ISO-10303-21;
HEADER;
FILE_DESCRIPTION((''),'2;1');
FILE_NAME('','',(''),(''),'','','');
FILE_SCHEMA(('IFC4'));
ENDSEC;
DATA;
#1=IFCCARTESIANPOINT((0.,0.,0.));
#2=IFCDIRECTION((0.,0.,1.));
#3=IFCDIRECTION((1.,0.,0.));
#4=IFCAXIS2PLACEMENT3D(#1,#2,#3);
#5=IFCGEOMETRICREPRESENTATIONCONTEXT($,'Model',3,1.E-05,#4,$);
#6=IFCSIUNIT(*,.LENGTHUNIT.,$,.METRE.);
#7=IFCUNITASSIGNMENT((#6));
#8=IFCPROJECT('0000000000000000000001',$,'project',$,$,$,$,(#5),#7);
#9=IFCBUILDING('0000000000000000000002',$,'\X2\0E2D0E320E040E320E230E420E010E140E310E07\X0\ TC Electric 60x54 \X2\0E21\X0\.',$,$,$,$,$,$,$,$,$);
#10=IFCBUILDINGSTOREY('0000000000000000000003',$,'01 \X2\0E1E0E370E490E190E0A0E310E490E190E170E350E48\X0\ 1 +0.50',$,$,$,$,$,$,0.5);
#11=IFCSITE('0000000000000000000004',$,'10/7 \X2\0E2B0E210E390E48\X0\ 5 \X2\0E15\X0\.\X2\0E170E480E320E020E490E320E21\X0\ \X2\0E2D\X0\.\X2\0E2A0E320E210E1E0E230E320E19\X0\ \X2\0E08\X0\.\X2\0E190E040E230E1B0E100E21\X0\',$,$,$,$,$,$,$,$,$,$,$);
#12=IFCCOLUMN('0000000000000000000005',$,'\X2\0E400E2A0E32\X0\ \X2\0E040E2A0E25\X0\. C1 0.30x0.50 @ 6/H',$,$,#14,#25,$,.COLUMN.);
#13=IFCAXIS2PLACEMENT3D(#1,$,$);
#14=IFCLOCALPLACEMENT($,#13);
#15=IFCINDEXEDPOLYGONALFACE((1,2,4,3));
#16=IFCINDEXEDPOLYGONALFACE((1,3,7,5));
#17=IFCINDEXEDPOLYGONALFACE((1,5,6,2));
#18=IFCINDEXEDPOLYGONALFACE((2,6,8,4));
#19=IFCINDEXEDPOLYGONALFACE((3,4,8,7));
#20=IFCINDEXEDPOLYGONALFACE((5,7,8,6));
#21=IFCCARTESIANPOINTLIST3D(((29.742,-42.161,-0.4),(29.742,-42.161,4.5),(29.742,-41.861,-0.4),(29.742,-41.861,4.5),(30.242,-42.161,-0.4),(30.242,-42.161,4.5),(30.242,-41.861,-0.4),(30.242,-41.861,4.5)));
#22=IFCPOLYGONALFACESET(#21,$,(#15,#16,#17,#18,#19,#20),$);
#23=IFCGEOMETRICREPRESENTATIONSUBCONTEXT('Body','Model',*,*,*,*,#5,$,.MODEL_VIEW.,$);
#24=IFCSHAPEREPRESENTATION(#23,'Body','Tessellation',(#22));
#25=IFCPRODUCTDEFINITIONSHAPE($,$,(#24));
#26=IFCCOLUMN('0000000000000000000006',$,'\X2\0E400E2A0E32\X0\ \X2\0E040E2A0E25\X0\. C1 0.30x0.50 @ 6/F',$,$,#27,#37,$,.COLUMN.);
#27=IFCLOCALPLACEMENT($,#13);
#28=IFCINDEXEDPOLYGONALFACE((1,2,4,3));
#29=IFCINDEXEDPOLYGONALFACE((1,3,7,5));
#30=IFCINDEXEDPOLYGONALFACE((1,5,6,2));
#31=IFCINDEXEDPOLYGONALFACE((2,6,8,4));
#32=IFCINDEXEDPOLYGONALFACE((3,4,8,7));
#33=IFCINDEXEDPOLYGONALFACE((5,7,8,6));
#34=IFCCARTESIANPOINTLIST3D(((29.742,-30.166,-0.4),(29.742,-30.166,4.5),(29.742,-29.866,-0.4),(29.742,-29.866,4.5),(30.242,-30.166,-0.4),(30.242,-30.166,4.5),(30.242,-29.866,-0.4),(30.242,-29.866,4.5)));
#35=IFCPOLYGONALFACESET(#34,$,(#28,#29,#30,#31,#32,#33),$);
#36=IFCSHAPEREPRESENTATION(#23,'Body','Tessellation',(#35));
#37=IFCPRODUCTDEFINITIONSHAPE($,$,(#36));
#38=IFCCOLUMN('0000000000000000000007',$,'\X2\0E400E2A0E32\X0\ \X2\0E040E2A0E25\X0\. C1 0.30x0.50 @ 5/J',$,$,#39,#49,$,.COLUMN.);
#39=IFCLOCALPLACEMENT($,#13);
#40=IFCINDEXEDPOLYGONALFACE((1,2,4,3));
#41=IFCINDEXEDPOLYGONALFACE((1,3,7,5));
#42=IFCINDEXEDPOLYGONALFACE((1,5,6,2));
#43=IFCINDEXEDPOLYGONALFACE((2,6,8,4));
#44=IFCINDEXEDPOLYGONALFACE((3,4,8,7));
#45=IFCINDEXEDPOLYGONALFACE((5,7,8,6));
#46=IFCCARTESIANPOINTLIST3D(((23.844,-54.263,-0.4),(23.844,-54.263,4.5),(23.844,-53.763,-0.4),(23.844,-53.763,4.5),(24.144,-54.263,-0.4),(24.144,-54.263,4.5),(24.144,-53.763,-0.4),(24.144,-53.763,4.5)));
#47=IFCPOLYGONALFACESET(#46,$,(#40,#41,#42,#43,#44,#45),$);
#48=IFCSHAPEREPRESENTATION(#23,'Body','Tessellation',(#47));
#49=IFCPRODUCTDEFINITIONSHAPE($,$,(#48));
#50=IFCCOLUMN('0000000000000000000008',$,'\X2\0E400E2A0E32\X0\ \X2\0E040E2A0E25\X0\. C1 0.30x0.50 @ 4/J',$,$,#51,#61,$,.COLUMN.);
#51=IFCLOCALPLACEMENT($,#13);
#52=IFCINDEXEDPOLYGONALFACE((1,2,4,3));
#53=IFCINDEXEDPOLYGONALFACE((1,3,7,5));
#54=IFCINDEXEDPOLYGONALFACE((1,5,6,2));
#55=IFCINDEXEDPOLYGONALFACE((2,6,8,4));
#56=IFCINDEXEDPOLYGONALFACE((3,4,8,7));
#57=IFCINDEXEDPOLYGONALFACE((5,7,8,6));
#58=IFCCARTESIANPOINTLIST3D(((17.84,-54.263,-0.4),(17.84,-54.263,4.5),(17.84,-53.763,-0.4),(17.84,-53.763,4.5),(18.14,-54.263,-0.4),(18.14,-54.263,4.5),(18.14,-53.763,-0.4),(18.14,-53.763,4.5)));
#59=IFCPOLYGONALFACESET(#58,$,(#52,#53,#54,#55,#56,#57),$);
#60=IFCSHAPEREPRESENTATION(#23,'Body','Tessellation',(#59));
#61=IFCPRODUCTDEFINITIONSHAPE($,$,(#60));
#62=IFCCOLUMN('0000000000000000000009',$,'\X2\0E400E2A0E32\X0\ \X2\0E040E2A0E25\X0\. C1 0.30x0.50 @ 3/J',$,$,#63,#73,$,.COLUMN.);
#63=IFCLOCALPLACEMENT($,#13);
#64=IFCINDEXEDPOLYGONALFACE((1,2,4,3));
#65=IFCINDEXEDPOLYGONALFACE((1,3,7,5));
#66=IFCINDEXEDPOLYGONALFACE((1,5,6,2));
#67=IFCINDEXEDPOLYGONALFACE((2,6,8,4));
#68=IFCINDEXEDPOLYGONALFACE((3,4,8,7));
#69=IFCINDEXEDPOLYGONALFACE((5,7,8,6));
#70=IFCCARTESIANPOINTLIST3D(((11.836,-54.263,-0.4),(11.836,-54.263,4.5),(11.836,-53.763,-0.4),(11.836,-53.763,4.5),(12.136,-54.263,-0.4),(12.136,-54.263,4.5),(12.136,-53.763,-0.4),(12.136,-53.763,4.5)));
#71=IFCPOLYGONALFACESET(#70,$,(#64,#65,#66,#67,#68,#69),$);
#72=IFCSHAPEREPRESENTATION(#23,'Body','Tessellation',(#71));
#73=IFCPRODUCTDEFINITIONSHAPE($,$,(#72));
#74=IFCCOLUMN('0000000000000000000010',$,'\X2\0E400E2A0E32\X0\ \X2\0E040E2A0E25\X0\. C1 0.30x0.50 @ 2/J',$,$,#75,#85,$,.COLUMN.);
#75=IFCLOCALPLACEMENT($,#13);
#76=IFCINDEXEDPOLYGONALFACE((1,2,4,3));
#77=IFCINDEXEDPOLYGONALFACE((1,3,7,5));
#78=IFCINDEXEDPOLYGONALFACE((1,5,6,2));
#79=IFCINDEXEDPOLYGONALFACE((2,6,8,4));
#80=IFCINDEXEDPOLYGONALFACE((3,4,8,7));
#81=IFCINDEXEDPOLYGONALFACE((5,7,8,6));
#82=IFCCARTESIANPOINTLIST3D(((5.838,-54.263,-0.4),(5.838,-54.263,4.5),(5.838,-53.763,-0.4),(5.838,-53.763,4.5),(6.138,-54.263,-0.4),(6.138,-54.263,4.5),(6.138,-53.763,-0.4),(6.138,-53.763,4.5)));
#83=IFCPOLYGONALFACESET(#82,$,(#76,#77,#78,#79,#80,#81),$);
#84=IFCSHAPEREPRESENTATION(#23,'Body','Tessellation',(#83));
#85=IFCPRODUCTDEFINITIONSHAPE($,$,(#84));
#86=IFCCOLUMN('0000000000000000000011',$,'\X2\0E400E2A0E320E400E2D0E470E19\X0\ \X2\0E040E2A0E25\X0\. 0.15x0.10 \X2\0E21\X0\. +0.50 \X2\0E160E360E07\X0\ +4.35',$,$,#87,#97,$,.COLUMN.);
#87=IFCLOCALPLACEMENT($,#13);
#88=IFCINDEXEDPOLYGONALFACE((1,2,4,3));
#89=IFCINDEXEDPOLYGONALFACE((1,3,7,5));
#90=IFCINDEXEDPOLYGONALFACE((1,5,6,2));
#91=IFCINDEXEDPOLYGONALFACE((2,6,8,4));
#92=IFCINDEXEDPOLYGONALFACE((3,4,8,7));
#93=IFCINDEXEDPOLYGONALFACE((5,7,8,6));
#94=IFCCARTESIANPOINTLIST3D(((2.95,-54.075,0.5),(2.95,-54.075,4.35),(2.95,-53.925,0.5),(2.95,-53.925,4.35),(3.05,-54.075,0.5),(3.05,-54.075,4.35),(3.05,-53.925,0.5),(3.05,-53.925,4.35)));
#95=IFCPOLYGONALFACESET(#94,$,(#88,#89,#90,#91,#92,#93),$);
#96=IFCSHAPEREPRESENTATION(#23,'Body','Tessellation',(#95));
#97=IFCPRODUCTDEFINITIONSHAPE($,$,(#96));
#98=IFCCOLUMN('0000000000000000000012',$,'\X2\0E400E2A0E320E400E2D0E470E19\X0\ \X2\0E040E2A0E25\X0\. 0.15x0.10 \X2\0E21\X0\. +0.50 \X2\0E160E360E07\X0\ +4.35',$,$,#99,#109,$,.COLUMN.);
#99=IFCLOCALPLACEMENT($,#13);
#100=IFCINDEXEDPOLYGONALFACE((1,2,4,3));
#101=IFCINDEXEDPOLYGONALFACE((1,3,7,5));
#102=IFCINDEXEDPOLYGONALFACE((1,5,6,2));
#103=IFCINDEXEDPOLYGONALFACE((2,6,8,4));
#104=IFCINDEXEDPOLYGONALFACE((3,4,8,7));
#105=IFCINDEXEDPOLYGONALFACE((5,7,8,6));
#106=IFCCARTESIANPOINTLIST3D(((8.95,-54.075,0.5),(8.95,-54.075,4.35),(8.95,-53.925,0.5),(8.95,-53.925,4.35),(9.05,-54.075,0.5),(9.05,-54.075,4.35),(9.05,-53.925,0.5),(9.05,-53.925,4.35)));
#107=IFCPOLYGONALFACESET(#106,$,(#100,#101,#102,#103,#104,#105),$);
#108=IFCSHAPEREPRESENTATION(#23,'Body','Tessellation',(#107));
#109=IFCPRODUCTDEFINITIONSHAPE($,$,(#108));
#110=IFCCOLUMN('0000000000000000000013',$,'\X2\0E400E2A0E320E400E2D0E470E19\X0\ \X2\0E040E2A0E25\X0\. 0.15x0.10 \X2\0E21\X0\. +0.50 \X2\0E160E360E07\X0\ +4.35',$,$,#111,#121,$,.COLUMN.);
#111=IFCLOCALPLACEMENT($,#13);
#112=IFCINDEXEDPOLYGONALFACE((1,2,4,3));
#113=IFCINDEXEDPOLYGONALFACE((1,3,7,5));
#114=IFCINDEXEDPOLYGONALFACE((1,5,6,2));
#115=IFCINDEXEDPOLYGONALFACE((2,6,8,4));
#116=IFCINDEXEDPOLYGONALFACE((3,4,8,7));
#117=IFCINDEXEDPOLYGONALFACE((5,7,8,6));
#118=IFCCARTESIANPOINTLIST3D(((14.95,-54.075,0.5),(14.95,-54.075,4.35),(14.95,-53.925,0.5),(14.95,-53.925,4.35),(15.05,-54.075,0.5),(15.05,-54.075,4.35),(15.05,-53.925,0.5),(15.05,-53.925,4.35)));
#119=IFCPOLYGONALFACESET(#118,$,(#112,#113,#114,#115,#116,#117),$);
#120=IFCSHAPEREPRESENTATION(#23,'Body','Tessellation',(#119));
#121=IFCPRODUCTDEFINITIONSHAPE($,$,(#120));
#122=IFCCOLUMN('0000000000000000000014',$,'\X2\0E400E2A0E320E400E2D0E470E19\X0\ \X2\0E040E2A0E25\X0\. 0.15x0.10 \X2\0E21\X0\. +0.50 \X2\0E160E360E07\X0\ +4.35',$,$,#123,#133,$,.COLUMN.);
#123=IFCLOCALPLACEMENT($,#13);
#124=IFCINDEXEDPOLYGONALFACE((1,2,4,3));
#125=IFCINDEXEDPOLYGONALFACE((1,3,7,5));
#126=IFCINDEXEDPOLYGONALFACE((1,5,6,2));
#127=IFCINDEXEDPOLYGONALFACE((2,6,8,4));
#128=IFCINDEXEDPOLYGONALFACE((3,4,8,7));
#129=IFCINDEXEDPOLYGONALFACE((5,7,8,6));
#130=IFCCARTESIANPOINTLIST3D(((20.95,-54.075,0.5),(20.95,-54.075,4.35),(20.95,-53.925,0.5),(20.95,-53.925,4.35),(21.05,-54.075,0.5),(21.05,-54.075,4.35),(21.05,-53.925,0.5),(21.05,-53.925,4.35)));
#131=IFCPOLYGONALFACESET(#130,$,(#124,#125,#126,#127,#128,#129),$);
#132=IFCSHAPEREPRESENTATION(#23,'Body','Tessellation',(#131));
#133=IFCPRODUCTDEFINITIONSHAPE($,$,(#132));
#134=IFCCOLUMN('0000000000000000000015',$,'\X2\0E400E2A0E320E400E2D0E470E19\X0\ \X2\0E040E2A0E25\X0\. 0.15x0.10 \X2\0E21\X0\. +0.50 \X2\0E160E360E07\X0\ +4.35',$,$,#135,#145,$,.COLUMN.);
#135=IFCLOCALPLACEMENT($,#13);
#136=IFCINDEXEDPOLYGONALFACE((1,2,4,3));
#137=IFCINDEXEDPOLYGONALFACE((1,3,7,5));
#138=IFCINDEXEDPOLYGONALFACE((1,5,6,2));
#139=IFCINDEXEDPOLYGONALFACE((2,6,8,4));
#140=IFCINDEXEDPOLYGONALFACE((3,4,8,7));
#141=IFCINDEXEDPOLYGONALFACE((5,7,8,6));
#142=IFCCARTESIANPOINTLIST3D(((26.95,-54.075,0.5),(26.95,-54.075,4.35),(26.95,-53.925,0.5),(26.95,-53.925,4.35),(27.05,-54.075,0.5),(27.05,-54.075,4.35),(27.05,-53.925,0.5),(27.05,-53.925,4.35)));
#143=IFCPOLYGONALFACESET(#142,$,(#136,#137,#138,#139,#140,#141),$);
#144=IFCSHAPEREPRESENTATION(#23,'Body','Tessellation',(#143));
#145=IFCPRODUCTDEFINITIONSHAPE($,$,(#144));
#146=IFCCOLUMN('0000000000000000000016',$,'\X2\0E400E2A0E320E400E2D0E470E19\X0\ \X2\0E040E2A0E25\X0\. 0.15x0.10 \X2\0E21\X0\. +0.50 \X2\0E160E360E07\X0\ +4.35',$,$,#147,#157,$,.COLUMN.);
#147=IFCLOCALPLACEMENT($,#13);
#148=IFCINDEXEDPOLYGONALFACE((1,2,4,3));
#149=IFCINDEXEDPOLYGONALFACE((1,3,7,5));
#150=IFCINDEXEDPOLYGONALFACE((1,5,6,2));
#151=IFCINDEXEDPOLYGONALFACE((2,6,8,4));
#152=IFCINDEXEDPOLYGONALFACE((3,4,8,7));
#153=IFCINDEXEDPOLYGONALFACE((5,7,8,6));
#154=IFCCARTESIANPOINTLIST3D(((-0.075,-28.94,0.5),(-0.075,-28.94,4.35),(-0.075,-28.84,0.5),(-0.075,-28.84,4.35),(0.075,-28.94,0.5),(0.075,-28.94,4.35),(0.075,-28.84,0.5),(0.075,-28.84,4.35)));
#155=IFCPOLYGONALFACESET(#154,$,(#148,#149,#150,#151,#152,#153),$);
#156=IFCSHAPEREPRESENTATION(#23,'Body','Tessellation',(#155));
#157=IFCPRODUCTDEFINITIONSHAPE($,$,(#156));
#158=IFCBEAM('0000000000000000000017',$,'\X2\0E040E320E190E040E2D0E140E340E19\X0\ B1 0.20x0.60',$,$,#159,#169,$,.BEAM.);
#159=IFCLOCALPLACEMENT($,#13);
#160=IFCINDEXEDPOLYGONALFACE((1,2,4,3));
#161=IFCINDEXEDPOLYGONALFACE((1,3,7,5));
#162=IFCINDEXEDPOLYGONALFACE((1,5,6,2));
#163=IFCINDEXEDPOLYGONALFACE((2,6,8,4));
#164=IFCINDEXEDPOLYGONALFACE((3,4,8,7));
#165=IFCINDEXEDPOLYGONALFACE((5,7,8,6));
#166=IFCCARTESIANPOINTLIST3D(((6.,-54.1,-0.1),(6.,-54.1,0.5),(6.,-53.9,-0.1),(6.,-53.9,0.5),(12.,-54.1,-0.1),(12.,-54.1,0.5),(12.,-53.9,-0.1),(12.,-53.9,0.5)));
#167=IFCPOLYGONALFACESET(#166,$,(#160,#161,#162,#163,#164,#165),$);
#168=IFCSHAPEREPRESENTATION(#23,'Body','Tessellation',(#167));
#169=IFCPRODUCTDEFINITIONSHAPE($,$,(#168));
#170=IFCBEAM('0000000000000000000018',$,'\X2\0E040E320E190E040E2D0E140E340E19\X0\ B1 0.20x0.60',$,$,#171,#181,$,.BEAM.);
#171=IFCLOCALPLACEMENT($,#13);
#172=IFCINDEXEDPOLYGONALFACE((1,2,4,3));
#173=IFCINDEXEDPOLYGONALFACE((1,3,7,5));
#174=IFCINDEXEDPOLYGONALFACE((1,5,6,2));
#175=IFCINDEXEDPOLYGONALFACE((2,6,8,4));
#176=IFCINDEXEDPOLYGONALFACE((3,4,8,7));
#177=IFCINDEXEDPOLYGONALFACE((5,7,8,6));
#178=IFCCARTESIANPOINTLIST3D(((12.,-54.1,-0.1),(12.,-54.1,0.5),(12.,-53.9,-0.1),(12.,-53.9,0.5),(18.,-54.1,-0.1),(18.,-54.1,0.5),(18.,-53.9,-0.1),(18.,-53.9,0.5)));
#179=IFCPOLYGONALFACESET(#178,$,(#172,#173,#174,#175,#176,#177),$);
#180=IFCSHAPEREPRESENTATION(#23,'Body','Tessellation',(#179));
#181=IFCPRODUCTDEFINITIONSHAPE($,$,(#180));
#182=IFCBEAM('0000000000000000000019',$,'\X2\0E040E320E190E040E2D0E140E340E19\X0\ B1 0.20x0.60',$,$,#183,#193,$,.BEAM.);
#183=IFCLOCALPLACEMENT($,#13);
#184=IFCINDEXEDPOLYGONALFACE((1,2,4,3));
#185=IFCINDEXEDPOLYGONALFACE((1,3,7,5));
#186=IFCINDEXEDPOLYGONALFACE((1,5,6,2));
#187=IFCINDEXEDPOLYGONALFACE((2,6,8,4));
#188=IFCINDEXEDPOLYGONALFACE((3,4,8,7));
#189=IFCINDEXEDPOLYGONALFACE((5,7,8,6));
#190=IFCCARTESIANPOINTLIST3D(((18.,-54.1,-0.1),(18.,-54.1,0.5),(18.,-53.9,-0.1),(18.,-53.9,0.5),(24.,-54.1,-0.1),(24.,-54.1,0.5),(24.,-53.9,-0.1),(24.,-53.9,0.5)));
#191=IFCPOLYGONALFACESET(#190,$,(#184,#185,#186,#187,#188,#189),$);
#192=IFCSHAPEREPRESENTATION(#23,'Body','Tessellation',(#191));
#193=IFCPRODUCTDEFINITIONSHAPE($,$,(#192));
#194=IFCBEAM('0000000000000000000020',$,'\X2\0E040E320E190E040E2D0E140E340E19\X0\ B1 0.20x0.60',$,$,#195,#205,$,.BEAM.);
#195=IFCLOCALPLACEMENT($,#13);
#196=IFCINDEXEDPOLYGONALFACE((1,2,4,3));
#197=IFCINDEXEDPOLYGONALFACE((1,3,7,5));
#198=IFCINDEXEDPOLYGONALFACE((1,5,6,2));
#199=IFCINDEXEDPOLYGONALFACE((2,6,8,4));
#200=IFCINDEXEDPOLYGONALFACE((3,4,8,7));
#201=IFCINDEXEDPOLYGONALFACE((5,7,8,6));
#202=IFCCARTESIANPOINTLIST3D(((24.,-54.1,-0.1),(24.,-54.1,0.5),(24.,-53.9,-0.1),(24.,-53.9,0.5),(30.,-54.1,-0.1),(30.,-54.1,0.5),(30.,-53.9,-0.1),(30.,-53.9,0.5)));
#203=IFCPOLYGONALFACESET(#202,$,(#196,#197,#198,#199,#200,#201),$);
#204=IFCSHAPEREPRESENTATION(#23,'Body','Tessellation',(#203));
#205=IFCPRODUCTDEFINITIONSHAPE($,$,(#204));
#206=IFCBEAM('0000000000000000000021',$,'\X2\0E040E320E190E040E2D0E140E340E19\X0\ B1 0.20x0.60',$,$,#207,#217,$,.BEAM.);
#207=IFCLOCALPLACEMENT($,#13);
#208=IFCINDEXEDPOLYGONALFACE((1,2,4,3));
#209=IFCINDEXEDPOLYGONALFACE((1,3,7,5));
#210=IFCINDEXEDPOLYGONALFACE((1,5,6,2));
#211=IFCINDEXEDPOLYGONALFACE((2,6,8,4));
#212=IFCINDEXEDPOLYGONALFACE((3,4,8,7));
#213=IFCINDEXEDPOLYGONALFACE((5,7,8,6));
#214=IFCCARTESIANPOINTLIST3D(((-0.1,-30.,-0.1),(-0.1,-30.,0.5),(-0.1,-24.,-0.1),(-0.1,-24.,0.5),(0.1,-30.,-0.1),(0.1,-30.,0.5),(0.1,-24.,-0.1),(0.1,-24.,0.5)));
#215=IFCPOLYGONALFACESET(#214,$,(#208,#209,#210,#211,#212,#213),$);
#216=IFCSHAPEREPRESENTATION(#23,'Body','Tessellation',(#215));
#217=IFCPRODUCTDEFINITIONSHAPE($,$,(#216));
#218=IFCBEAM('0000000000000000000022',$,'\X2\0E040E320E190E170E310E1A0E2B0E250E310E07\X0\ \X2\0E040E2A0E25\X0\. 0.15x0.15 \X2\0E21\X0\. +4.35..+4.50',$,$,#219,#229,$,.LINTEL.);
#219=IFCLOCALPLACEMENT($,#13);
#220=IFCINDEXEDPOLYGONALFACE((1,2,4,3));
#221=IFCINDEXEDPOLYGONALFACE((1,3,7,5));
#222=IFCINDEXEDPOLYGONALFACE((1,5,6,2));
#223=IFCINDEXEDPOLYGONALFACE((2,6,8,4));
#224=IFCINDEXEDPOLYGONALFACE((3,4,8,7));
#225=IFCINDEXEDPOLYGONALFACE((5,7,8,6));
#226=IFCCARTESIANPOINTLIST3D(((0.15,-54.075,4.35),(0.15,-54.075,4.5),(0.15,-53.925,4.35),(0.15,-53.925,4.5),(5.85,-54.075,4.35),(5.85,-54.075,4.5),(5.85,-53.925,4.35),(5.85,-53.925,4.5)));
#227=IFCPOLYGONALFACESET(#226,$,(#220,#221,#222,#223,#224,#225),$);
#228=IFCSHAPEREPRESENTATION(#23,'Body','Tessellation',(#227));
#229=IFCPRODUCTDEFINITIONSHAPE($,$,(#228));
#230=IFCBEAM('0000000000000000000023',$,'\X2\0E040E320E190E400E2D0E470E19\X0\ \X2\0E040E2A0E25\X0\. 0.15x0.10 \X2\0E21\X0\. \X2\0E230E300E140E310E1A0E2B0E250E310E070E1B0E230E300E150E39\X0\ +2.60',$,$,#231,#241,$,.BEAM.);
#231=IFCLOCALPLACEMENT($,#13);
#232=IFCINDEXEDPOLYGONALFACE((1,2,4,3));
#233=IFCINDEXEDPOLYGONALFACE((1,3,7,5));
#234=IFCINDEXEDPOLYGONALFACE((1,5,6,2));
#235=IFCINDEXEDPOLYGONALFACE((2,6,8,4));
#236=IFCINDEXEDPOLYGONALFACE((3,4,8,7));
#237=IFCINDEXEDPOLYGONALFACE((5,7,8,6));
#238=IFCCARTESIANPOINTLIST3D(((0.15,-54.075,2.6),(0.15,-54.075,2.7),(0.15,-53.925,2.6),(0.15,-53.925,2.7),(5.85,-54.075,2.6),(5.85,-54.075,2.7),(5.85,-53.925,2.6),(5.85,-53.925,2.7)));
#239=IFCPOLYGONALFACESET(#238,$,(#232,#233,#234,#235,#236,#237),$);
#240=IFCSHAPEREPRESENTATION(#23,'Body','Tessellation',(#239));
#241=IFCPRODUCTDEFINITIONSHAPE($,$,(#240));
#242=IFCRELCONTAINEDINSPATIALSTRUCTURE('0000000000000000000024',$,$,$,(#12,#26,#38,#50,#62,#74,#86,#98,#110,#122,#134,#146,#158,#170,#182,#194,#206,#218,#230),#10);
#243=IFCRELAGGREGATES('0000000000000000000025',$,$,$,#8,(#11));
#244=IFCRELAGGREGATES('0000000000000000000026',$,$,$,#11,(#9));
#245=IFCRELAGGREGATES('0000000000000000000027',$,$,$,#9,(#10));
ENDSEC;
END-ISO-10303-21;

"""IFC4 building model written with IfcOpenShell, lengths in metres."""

from ifc_helpers import new_model, si_unit, frame, origin, origin_with_axes, origin_2d, place, context, subcontext, project, spatial, rectangle, extrude, element, save


model = new_model("IFC4")

# Units and contexts
model_context = context("Model", 3, precision=1e-05, world=origin_with_axes())
body_context = subcontext(model_context, "Body", "Model", "MODEL_VIEW")
ifc_project = project(units=[si_unit("LENGTHUNIT", "METRE")], contexts=[model_context])

# Site, building, storey
site = spatial("IfcSite", under=ifc_project, Name="10/7 หมู่ 5 ต.ท่าข้าม อ.สามพราน จ.นครปฐม")
building = spatial("IfcBuilding", under=site, Name="อาคารโกดัง TC Electric 60x54 ม.")
storey = spatial("IfcBuildingStorey", under=building, Name="01 พื้นชั้นที่ 1 +0.50", Elevation=0.5)

# Columns
for number, where, z_axis, x_axis, name in (
    (1, (29.992, -42.011, -0.4), (0.0, 0.0, 1.0), (1.0, 0.0, 0.0), "เสา คสล. C1 0.30x0.50 @ 6/H"),
    (2, (29.992, -30.016, -0.4), (0.0, 0.0, 1.0), (1.0, 0.0, 0.0), "เสา คสล. C1 0.30x0.50 @ 6/F"),
):
    element("IfcColumn", number, at=place(None, frame(where, z_axis=z_axis, x_axis=x_axis)), inside=storey, Name=name, PredefinedType="COLUMN", context=body_context, shape_type="SweptSolid", body=[
        extrude(rectangle(XDim=0.5, YDim=0.3, at=origin_2d()), origin(), (0.0, 0.0, 1.0), 4.9),
    ])
for number, where, z_axis, x_axis, name in (
    (3, (23.994, -54.013, -0.4), (0.0, 0.0, 1.0), (1.0, 0.0, 0.0), "เสา คสล. C1 0.30x0.50 @ 5/J"),
    (4, (17.99, -54.013, -0.4), (0.0, 0.0, 1.0), (1.0, 0.0, 0.0), "เสา คสล. C1 0.30x0.50 @ 4/J"),
    (5, (11.986, -54.013, -0.4), (0.0, 0.0, 1.0), (1.0, 0.0, 0.0), "เสา คสล. C1 0.30x0.50 @ 3/J"),
    (6, (5.988, -54.013, -0.4), (0.0, 0.0, 1.0), (1.0, 0.0, 0.0), "เสา คสล. C1 0.30x0.50 @ 2/J"),
):
    element("IfcColumn", number, at=place(None, frame(where, z_axis=z_axis, x_axis=x_axis)), inside=storey, Name=name, PredefinedType="COLUMN", context=body_context, shape_type="SweptSolid", body=[
        extrude(rectangle(XDim=0.3, YDim=0.5, at=origin_2d()), origin(), (0.0, 0.0, 1.0), 4.9),
    ])
for number, where, z_axis, x_axis, name in (
    (7, (3.0, -54.0, 0.5), (0.0, 0.0, 1.0), (1.0, 0.0, 0.0), "เสาเอ็น คสล. 0.15x0.10 ม. +0.50 ถึง +4.35"),
    (8, (9.0, -54.0, 0.5), (0.0, 0.0, 1.0), (1.0, 0.0, 0.0), "เสาเอ็น คสล. 0.15x0.10 ม. +0.50 ถึง +4.35"),
    (9, (15.0, -54.0, 0.5), (0.0, 0.0, 1.0), (1.0, 0.0, 0.0), "เสาเอ็น คสล. 0.15x0.10 ม. +0.50 ถึง +4.35"),
    (10, (21.0, -54.0, 0.5), (0.0, 0.0, 1.0), (1.0, 0.0, 0.0), "เสาเอ็น คสล. 0.15x0.10 ม. +0.50 ถึง +4.35"),
    (11, (27.0, -54.0, 0.5), (0.0, 0.0, 1.0), (1.0, 0.0, 0.0), "เสาเอ็น คสล. 0.15x0.10 ม. +0.50 ถึง +4.35"),
):
    element("IfcColumn", number, at=place(None, frame(where, z_axis=z_axis, x_axis=x_axis)), inside=storey, Name=name, PredefinedType="COLUMN", context=body_context, shape_type="SweptSolid", body=[
        extrude(rectangle(XDim=0.1, YDim=0.15, at=origin_2d()), origin(), (0.0, 0.0, 1.0), 3.85),
    ])
column_placement = place(None, frame((0.0, -28.89, 0.5), z_axis=(0.0, 0.0, 1.0), x_axis=(1.0, 0.0, 0.0)))
element("IfcColumn", 12, at=column_placement, inside=storey, Name="เสาเอ็น คสล. 0.15x0.10 ม. +0.50 ถึง +4.35", PredefinedType="COLUMN", context=body_context, shape_type="SweptSolid", body=[
    extrude(rectangle(XDim=0.15, YDim=0.1, at=origin_2d()), origin(), (0.0, 0.0, 1.0), 3.85),
])

# Beams
for number, where, z_axis, x_axis, name in (
    (13, (6.0, -54.0, 0.2), (1.0, 0.0, 0.0), (0.0, -1.0, 0.0), "คานคอดิน B1 0.20x0.60"),
    (14, (12.0, -54.0, 0.2), (1.0, 0.0, 0.0), (0.0, -1.0, 0.0), "คานคอดิน B1 0.20x0.60"),
    (15, (18.0, -54.0, 0.2), (1.0, 0.0, 0.0), (0.0, -1.0, 0.0), "คานคอดิน B1 0.20x0.60"),
    (16, (24.0, -54.0, 0.2), (1.0, 0.0, 0.0), (0.0, -1.0, 0.0), "คานคอดิน B1 0.20x0.60"),
    (17, (0.0, -24.0, 0.2), (0.0, -1.0, 0.0), (-1.0, 0.0, 0.0), "คานคอดิน B1 0.20x0.60"),
):
    element("IfcBeam", number, at=place(None, frame(where, z_axis=z_axis, x_axis=x_axis)), inside=storey, Name=name, PredefinedType="BEAM", context=body_context, shape_type="SweptSolid", body=[
        extrude(rectangle(XDim=0.2, YDim=0.6, at=origin_2d()), origin(), (0.0, 0.0, 1.0), 6.0),
    ])
beam_1_placement = place(None, frame((0.15, -54.0, 4.425), z_axis=(1.0, 0.0, 0.0), x_axis=(0.0, -1.0, 0.0)))
element("IfcBeam", 18, at=beam_1_placement, inside=storey, Name="คานทับหลัง คสล. 0.15x0.15 ม. +4.35..+4.50", PredefinedType="LINTEL", context=body_context, shape_type="SweptSolid", body=[
    extrude(rectangle(XDim=0.15, YDim=0.15, at=origin_2d()), origin(), (0.0, 0.0, 1.0), 5.7),
])
beam_2_placement = place(None, frame((0.15, -54.0, 2.65), z_axis=(1.0, 0.0, 0.0), x_axis=(0.0, -1.0, 0.0)))
element("IfcBeam", 19, at=beam_2_placement, inside=storey, Name="คานเอ็น คสล. 0.15x0.10 ม. ระดับหลังประตู +2.60", PredefinedType="BEAM", context=body_context, shape_type="SweptSolid", body=[
    extrude(rectangle(XDim=0.15, YDim=0.1, at=origin_2d()), origin(), (0.0, 0.0, 1.0), 5.7),
])

save(model, "model.ifc")
